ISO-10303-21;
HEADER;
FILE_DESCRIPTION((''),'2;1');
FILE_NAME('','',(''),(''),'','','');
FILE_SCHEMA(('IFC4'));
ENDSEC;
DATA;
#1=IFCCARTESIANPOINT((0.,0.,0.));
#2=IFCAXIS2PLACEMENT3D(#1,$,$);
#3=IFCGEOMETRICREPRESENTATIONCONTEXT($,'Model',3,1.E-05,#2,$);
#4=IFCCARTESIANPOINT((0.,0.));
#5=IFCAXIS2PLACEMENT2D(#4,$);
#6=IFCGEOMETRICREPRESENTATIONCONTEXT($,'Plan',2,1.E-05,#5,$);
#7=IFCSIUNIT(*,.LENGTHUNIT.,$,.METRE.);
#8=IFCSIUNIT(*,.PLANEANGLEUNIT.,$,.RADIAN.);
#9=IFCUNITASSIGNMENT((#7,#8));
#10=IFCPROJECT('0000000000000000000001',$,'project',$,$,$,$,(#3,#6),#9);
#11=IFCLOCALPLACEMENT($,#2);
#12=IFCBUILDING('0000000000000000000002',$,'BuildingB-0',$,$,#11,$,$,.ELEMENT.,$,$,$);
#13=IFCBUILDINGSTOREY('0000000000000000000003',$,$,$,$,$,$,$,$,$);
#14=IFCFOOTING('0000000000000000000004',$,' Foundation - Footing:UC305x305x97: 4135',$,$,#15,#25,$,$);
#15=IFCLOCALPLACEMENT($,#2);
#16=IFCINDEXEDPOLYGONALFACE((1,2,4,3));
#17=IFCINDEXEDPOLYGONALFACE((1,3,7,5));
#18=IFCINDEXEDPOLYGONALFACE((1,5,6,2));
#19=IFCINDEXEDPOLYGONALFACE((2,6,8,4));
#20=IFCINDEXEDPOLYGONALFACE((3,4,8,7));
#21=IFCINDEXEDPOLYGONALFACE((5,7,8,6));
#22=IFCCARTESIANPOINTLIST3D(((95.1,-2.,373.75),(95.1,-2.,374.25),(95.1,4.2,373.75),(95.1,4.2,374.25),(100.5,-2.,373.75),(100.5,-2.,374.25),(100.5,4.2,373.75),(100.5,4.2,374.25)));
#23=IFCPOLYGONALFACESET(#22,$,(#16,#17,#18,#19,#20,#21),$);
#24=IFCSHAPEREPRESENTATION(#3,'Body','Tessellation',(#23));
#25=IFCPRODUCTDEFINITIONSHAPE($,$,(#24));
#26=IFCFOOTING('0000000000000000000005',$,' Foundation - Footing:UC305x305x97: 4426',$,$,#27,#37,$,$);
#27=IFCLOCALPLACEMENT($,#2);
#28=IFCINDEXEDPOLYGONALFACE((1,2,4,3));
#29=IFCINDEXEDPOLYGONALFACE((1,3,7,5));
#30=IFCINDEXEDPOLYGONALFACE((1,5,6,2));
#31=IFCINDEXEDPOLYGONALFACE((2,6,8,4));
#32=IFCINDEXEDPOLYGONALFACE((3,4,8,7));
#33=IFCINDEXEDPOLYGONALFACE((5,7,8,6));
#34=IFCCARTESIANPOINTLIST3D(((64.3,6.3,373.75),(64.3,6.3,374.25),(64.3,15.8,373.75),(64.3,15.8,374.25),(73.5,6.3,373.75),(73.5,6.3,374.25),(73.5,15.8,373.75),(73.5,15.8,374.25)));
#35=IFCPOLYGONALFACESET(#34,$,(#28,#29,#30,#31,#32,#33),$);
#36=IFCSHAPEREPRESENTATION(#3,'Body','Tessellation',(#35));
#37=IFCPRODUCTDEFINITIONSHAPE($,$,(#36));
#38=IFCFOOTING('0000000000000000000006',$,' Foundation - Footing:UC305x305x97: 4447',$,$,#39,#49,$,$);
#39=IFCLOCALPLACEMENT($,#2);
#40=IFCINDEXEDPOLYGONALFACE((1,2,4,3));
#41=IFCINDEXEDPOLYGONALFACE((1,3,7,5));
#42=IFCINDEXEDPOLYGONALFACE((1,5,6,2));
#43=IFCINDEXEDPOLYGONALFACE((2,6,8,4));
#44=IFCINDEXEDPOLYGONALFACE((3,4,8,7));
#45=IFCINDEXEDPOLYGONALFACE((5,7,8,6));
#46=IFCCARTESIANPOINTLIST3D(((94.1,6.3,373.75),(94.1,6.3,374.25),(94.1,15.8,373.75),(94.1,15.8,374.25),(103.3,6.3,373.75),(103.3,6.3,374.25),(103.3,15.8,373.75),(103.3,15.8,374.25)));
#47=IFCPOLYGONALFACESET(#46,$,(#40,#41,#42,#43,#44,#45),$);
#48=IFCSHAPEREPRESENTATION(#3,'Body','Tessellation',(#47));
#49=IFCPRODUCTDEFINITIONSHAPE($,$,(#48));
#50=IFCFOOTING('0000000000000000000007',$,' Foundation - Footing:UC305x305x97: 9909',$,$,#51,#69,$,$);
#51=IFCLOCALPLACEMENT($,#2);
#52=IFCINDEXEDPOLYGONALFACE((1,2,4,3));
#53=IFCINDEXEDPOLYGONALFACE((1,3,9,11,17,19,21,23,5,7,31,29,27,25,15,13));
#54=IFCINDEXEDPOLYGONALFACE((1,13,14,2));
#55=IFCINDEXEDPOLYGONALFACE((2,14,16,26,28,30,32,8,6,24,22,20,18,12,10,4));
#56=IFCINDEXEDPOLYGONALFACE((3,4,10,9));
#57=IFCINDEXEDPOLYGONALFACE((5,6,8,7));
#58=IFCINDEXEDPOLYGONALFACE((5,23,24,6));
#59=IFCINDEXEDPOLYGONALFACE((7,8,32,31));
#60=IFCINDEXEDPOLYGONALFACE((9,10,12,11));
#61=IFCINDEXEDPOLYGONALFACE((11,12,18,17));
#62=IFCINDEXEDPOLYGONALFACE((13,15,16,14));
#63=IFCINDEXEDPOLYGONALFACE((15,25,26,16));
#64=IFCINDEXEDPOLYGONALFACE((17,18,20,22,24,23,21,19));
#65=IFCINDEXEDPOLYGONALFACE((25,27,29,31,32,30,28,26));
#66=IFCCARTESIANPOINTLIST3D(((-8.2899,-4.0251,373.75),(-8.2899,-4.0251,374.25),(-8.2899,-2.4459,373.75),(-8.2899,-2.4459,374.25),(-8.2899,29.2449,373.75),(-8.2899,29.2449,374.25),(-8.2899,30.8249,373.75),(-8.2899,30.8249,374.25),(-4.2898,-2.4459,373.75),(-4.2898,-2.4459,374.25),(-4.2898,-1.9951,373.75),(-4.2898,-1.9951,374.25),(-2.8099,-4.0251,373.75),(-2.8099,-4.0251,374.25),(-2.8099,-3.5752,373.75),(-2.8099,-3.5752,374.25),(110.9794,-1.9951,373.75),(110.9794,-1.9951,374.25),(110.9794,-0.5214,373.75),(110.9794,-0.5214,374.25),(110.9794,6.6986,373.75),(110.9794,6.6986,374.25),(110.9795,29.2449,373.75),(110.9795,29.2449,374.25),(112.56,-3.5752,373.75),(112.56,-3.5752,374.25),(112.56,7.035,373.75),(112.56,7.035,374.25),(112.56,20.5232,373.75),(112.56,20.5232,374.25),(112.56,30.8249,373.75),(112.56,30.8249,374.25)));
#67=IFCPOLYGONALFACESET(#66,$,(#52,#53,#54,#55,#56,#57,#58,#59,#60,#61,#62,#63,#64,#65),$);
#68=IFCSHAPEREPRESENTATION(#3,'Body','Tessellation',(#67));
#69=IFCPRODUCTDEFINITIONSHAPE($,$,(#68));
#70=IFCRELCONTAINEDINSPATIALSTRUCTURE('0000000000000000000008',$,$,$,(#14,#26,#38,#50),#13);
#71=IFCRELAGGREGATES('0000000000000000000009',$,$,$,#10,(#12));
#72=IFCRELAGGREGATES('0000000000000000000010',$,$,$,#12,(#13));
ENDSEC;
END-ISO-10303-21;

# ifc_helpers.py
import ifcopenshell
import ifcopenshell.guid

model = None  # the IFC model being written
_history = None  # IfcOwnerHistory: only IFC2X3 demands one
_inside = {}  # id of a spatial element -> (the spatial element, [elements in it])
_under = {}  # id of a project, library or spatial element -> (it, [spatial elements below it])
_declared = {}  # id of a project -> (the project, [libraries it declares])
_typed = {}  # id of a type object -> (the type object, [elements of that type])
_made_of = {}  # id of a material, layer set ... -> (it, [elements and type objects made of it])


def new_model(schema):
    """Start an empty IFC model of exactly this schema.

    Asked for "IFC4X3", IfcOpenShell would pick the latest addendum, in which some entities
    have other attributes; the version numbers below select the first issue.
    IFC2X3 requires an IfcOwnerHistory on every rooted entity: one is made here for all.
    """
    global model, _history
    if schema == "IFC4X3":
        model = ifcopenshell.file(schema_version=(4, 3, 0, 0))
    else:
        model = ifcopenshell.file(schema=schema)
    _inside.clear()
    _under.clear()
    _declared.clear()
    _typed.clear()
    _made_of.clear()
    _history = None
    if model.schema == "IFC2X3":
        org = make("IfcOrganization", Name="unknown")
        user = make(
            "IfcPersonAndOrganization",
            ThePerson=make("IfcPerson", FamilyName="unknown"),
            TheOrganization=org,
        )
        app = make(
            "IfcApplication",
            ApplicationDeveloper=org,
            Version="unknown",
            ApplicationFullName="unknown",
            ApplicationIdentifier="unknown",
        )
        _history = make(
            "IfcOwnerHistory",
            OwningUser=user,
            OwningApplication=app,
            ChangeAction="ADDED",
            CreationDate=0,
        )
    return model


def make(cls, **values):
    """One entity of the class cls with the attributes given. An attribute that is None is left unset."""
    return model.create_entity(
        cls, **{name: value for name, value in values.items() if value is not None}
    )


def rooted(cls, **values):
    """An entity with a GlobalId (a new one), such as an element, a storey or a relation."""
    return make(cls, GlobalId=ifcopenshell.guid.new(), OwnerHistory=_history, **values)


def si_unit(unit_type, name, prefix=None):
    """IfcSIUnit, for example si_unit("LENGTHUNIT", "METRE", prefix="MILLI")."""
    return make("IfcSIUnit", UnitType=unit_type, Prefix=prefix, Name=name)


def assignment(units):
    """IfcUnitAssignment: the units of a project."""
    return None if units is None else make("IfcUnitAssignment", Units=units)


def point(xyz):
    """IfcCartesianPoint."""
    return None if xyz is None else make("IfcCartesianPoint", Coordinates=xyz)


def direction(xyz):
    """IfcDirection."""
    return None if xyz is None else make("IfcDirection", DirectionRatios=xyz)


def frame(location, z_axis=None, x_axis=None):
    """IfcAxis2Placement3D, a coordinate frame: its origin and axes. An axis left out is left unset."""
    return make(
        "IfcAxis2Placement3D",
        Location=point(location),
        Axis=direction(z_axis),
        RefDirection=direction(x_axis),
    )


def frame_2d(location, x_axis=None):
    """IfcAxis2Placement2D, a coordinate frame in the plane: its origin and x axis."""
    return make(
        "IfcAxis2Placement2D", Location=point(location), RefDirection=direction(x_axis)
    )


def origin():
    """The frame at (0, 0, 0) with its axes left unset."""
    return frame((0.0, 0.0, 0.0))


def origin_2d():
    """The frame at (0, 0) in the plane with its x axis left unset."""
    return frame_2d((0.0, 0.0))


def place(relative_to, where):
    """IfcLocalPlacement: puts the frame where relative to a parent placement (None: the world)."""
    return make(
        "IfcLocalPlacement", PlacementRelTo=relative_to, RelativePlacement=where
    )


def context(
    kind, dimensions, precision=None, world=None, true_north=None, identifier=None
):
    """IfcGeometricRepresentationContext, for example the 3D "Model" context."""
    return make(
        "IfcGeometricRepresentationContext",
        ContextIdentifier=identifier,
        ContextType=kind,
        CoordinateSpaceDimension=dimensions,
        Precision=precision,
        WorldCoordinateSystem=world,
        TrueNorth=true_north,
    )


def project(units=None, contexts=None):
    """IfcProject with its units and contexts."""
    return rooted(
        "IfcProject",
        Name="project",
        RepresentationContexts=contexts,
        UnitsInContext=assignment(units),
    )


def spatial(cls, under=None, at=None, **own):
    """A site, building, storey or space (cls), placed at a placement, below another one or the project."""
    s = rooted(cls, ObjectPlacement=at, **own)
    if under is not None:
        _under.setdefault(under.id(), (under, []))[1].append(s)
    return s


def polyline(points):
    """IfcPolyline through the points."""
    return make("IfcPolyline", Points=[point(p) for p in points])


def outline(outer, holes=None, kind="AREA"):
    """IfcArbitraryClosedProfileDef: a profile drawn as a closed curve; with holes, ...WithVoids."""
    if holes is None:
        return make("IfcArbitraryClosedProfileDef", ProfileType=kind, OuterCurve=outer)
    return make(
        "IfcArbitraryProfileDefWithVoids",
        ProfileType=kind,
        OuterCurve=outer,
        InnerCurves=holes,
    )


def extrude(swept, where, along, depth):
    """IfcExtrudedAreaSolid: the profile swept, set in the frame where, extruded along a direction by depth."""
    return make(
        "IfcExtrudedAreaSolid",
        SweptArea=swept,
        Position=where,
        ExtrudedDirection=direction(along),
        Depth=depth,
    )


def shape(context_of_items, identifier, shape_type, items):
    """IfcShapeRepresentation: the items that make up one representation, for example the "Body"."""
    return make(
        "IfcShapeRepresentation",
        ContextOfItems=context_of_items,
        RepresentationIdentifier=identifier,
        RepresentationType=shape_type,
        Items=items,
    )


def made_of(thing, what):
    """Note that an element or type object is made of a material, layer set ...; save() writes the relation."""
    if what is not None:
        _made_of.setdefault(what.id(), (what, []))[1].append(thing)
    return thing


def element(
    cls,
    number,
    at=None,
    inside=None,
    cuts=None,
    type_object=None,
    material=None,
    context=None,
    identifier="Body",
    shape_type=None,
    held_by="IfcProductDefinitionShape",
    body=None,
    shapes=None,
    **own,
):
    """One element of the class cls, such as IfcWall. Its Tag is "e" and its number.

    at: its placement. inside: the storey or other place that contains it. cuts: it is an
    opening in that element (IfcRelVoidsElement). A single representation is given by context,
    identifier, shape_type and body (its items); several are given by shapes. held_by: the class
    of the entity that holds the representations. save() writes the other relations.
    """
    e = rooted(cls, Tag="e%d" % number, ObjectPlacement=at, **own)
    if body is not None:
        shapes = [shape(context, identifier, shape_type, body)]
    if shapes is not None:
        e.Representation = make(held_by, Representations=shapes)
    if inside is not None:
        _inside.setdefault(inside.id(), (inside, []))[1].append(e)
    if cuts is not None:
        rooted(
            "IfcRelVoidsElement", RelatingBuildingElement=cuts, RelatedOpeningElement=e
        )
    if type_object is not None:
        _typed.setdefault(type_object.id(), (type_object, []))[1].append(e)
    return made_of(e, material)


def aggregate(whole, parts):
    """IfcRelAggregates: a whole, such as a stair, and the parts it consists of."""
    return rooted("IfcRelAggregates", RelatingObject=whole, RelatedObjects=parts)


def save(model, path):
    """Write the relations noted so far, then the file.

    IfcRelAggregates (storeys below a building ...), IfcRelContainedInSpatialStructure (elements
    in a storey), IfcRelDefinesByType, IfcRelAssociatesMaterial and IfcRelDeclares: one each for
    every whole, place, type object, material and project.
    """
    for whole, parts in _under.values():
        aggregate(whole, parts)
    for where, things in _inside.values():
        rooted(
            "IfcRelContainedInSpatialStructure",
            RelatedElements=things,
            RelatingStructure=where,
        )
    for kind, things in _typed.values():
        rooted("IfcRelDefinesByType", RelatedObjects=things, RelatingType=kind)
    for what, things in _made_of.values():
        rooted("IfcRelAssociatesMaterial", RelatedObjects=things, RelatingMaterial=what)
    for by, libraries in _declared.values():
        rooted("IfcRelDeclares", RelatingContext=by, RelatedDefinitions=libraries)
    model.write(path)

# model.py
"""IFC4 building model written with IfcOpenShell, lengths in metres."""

from ifc_helpers import new_model, si_unit, origin, origin_2d, place, context, project, spatial, polyline, outline, extrude, element, save


model = new_model("IFC4")

# Units and contexts
model_context = context("Model", 3, precision=1e-05, world=origin())
plan_context = context("Plan", 2, precision=1e-05, world=origin_2d())
ifc_project = project(units=[si_unit("LENGTHUNIT", "METRE"), si_unit("PLANEANGLEUNIT", "RADIAN")], contexts=[model_context, plan_context])

# Building, storey
building_placement = place(None, origin())
building = spatial("IfcBuilding", under=ifc_project, at=building_placement, Name="BuildingB-0", CompositionType="ELEMENT")
storey = spatial("IfcBuildingStorey", under=building)

# Footings
element("IfcFooting", 1, inside=storey, Name=" Foundation - Footing:UC305x305x97: 4135", context=model_context, shape_type="SweptSolid", body=[
    extrude(outline(polyline([(100.5, -2.0, 373.75), (100.5, 4.2, 373.75), (95.1, 4.2, 373.75), (95.1, -2.0, 373.75), (100.5, -2.0, 373.75)])), None, (0.0, 0.0, 1.0), 0.5),
])
element("IfcFooting", 2, inside=storey, Name=" Foundation - Footing:UC305x305x97: 4426", context=model_context, shape_type="SweptSolid", body=[
    extrude(outline(polyline([(64.3, 15.8, 373.75), (73.5, 15.8, 373.75), (73.5, 6.3, 373.75), (64.3, 6.3, 373.75), (64.3, 15.8, 373.75)])), None, (0.0, 0.0, 1.0), 0.5),
])
element("IfcFooting", 3, inside=storey, Name=" Foundation - Footing:UC305x305x97: 4447", context=model_context, shape_type="SweptSolid", body=[
    extrude(outline(polyline([(94.1, 15.8, 373.75), (103.3, 15.8, 373.75), (103.3, 6.3, 373.75), (94.1, 6.3, 373.75), (94.1, 15.8, 373.75)])), None, (0.0, 0.0, 1.0), 0.5),
])
element("IfcFooting", 4, inside=storey, Name=" Foundation - Footing:UC305x305x97: 9909", context=model_context, shape_type="SweptSolid", body=[
    extrude(outline(polyline([(-8.2899, 30.8249, 373.75), (112.56, 30.8249, 373.75), (112.56, 20.5232, 373.75), (112.56, 7.035, 373.75), (112.56, -3.5752, 373.75), (-2.8099, -3.5752, 373.75), (-2.8099, -4.0251, 373.75), (-8.2899, -4.0251, 373.75), (-8.2899, -2.4459, 373.75), (-4.2898, -2.4459, 373.75), (-4.2898, -1.9951, 373.75), (110.9794, -1.9951, 373.75), (110.9794, -0.5214, 373.75), (110.9794, 6.6986, 373.75), (110.9795, 29.2449, 373.75), (-8.2899, 29.2449, 373.75), (-8.2899, 30.8249, 373.75)])), None, (0.0, 0.0, 1.0), 0.5),
])

save(model, "model.ifc")
